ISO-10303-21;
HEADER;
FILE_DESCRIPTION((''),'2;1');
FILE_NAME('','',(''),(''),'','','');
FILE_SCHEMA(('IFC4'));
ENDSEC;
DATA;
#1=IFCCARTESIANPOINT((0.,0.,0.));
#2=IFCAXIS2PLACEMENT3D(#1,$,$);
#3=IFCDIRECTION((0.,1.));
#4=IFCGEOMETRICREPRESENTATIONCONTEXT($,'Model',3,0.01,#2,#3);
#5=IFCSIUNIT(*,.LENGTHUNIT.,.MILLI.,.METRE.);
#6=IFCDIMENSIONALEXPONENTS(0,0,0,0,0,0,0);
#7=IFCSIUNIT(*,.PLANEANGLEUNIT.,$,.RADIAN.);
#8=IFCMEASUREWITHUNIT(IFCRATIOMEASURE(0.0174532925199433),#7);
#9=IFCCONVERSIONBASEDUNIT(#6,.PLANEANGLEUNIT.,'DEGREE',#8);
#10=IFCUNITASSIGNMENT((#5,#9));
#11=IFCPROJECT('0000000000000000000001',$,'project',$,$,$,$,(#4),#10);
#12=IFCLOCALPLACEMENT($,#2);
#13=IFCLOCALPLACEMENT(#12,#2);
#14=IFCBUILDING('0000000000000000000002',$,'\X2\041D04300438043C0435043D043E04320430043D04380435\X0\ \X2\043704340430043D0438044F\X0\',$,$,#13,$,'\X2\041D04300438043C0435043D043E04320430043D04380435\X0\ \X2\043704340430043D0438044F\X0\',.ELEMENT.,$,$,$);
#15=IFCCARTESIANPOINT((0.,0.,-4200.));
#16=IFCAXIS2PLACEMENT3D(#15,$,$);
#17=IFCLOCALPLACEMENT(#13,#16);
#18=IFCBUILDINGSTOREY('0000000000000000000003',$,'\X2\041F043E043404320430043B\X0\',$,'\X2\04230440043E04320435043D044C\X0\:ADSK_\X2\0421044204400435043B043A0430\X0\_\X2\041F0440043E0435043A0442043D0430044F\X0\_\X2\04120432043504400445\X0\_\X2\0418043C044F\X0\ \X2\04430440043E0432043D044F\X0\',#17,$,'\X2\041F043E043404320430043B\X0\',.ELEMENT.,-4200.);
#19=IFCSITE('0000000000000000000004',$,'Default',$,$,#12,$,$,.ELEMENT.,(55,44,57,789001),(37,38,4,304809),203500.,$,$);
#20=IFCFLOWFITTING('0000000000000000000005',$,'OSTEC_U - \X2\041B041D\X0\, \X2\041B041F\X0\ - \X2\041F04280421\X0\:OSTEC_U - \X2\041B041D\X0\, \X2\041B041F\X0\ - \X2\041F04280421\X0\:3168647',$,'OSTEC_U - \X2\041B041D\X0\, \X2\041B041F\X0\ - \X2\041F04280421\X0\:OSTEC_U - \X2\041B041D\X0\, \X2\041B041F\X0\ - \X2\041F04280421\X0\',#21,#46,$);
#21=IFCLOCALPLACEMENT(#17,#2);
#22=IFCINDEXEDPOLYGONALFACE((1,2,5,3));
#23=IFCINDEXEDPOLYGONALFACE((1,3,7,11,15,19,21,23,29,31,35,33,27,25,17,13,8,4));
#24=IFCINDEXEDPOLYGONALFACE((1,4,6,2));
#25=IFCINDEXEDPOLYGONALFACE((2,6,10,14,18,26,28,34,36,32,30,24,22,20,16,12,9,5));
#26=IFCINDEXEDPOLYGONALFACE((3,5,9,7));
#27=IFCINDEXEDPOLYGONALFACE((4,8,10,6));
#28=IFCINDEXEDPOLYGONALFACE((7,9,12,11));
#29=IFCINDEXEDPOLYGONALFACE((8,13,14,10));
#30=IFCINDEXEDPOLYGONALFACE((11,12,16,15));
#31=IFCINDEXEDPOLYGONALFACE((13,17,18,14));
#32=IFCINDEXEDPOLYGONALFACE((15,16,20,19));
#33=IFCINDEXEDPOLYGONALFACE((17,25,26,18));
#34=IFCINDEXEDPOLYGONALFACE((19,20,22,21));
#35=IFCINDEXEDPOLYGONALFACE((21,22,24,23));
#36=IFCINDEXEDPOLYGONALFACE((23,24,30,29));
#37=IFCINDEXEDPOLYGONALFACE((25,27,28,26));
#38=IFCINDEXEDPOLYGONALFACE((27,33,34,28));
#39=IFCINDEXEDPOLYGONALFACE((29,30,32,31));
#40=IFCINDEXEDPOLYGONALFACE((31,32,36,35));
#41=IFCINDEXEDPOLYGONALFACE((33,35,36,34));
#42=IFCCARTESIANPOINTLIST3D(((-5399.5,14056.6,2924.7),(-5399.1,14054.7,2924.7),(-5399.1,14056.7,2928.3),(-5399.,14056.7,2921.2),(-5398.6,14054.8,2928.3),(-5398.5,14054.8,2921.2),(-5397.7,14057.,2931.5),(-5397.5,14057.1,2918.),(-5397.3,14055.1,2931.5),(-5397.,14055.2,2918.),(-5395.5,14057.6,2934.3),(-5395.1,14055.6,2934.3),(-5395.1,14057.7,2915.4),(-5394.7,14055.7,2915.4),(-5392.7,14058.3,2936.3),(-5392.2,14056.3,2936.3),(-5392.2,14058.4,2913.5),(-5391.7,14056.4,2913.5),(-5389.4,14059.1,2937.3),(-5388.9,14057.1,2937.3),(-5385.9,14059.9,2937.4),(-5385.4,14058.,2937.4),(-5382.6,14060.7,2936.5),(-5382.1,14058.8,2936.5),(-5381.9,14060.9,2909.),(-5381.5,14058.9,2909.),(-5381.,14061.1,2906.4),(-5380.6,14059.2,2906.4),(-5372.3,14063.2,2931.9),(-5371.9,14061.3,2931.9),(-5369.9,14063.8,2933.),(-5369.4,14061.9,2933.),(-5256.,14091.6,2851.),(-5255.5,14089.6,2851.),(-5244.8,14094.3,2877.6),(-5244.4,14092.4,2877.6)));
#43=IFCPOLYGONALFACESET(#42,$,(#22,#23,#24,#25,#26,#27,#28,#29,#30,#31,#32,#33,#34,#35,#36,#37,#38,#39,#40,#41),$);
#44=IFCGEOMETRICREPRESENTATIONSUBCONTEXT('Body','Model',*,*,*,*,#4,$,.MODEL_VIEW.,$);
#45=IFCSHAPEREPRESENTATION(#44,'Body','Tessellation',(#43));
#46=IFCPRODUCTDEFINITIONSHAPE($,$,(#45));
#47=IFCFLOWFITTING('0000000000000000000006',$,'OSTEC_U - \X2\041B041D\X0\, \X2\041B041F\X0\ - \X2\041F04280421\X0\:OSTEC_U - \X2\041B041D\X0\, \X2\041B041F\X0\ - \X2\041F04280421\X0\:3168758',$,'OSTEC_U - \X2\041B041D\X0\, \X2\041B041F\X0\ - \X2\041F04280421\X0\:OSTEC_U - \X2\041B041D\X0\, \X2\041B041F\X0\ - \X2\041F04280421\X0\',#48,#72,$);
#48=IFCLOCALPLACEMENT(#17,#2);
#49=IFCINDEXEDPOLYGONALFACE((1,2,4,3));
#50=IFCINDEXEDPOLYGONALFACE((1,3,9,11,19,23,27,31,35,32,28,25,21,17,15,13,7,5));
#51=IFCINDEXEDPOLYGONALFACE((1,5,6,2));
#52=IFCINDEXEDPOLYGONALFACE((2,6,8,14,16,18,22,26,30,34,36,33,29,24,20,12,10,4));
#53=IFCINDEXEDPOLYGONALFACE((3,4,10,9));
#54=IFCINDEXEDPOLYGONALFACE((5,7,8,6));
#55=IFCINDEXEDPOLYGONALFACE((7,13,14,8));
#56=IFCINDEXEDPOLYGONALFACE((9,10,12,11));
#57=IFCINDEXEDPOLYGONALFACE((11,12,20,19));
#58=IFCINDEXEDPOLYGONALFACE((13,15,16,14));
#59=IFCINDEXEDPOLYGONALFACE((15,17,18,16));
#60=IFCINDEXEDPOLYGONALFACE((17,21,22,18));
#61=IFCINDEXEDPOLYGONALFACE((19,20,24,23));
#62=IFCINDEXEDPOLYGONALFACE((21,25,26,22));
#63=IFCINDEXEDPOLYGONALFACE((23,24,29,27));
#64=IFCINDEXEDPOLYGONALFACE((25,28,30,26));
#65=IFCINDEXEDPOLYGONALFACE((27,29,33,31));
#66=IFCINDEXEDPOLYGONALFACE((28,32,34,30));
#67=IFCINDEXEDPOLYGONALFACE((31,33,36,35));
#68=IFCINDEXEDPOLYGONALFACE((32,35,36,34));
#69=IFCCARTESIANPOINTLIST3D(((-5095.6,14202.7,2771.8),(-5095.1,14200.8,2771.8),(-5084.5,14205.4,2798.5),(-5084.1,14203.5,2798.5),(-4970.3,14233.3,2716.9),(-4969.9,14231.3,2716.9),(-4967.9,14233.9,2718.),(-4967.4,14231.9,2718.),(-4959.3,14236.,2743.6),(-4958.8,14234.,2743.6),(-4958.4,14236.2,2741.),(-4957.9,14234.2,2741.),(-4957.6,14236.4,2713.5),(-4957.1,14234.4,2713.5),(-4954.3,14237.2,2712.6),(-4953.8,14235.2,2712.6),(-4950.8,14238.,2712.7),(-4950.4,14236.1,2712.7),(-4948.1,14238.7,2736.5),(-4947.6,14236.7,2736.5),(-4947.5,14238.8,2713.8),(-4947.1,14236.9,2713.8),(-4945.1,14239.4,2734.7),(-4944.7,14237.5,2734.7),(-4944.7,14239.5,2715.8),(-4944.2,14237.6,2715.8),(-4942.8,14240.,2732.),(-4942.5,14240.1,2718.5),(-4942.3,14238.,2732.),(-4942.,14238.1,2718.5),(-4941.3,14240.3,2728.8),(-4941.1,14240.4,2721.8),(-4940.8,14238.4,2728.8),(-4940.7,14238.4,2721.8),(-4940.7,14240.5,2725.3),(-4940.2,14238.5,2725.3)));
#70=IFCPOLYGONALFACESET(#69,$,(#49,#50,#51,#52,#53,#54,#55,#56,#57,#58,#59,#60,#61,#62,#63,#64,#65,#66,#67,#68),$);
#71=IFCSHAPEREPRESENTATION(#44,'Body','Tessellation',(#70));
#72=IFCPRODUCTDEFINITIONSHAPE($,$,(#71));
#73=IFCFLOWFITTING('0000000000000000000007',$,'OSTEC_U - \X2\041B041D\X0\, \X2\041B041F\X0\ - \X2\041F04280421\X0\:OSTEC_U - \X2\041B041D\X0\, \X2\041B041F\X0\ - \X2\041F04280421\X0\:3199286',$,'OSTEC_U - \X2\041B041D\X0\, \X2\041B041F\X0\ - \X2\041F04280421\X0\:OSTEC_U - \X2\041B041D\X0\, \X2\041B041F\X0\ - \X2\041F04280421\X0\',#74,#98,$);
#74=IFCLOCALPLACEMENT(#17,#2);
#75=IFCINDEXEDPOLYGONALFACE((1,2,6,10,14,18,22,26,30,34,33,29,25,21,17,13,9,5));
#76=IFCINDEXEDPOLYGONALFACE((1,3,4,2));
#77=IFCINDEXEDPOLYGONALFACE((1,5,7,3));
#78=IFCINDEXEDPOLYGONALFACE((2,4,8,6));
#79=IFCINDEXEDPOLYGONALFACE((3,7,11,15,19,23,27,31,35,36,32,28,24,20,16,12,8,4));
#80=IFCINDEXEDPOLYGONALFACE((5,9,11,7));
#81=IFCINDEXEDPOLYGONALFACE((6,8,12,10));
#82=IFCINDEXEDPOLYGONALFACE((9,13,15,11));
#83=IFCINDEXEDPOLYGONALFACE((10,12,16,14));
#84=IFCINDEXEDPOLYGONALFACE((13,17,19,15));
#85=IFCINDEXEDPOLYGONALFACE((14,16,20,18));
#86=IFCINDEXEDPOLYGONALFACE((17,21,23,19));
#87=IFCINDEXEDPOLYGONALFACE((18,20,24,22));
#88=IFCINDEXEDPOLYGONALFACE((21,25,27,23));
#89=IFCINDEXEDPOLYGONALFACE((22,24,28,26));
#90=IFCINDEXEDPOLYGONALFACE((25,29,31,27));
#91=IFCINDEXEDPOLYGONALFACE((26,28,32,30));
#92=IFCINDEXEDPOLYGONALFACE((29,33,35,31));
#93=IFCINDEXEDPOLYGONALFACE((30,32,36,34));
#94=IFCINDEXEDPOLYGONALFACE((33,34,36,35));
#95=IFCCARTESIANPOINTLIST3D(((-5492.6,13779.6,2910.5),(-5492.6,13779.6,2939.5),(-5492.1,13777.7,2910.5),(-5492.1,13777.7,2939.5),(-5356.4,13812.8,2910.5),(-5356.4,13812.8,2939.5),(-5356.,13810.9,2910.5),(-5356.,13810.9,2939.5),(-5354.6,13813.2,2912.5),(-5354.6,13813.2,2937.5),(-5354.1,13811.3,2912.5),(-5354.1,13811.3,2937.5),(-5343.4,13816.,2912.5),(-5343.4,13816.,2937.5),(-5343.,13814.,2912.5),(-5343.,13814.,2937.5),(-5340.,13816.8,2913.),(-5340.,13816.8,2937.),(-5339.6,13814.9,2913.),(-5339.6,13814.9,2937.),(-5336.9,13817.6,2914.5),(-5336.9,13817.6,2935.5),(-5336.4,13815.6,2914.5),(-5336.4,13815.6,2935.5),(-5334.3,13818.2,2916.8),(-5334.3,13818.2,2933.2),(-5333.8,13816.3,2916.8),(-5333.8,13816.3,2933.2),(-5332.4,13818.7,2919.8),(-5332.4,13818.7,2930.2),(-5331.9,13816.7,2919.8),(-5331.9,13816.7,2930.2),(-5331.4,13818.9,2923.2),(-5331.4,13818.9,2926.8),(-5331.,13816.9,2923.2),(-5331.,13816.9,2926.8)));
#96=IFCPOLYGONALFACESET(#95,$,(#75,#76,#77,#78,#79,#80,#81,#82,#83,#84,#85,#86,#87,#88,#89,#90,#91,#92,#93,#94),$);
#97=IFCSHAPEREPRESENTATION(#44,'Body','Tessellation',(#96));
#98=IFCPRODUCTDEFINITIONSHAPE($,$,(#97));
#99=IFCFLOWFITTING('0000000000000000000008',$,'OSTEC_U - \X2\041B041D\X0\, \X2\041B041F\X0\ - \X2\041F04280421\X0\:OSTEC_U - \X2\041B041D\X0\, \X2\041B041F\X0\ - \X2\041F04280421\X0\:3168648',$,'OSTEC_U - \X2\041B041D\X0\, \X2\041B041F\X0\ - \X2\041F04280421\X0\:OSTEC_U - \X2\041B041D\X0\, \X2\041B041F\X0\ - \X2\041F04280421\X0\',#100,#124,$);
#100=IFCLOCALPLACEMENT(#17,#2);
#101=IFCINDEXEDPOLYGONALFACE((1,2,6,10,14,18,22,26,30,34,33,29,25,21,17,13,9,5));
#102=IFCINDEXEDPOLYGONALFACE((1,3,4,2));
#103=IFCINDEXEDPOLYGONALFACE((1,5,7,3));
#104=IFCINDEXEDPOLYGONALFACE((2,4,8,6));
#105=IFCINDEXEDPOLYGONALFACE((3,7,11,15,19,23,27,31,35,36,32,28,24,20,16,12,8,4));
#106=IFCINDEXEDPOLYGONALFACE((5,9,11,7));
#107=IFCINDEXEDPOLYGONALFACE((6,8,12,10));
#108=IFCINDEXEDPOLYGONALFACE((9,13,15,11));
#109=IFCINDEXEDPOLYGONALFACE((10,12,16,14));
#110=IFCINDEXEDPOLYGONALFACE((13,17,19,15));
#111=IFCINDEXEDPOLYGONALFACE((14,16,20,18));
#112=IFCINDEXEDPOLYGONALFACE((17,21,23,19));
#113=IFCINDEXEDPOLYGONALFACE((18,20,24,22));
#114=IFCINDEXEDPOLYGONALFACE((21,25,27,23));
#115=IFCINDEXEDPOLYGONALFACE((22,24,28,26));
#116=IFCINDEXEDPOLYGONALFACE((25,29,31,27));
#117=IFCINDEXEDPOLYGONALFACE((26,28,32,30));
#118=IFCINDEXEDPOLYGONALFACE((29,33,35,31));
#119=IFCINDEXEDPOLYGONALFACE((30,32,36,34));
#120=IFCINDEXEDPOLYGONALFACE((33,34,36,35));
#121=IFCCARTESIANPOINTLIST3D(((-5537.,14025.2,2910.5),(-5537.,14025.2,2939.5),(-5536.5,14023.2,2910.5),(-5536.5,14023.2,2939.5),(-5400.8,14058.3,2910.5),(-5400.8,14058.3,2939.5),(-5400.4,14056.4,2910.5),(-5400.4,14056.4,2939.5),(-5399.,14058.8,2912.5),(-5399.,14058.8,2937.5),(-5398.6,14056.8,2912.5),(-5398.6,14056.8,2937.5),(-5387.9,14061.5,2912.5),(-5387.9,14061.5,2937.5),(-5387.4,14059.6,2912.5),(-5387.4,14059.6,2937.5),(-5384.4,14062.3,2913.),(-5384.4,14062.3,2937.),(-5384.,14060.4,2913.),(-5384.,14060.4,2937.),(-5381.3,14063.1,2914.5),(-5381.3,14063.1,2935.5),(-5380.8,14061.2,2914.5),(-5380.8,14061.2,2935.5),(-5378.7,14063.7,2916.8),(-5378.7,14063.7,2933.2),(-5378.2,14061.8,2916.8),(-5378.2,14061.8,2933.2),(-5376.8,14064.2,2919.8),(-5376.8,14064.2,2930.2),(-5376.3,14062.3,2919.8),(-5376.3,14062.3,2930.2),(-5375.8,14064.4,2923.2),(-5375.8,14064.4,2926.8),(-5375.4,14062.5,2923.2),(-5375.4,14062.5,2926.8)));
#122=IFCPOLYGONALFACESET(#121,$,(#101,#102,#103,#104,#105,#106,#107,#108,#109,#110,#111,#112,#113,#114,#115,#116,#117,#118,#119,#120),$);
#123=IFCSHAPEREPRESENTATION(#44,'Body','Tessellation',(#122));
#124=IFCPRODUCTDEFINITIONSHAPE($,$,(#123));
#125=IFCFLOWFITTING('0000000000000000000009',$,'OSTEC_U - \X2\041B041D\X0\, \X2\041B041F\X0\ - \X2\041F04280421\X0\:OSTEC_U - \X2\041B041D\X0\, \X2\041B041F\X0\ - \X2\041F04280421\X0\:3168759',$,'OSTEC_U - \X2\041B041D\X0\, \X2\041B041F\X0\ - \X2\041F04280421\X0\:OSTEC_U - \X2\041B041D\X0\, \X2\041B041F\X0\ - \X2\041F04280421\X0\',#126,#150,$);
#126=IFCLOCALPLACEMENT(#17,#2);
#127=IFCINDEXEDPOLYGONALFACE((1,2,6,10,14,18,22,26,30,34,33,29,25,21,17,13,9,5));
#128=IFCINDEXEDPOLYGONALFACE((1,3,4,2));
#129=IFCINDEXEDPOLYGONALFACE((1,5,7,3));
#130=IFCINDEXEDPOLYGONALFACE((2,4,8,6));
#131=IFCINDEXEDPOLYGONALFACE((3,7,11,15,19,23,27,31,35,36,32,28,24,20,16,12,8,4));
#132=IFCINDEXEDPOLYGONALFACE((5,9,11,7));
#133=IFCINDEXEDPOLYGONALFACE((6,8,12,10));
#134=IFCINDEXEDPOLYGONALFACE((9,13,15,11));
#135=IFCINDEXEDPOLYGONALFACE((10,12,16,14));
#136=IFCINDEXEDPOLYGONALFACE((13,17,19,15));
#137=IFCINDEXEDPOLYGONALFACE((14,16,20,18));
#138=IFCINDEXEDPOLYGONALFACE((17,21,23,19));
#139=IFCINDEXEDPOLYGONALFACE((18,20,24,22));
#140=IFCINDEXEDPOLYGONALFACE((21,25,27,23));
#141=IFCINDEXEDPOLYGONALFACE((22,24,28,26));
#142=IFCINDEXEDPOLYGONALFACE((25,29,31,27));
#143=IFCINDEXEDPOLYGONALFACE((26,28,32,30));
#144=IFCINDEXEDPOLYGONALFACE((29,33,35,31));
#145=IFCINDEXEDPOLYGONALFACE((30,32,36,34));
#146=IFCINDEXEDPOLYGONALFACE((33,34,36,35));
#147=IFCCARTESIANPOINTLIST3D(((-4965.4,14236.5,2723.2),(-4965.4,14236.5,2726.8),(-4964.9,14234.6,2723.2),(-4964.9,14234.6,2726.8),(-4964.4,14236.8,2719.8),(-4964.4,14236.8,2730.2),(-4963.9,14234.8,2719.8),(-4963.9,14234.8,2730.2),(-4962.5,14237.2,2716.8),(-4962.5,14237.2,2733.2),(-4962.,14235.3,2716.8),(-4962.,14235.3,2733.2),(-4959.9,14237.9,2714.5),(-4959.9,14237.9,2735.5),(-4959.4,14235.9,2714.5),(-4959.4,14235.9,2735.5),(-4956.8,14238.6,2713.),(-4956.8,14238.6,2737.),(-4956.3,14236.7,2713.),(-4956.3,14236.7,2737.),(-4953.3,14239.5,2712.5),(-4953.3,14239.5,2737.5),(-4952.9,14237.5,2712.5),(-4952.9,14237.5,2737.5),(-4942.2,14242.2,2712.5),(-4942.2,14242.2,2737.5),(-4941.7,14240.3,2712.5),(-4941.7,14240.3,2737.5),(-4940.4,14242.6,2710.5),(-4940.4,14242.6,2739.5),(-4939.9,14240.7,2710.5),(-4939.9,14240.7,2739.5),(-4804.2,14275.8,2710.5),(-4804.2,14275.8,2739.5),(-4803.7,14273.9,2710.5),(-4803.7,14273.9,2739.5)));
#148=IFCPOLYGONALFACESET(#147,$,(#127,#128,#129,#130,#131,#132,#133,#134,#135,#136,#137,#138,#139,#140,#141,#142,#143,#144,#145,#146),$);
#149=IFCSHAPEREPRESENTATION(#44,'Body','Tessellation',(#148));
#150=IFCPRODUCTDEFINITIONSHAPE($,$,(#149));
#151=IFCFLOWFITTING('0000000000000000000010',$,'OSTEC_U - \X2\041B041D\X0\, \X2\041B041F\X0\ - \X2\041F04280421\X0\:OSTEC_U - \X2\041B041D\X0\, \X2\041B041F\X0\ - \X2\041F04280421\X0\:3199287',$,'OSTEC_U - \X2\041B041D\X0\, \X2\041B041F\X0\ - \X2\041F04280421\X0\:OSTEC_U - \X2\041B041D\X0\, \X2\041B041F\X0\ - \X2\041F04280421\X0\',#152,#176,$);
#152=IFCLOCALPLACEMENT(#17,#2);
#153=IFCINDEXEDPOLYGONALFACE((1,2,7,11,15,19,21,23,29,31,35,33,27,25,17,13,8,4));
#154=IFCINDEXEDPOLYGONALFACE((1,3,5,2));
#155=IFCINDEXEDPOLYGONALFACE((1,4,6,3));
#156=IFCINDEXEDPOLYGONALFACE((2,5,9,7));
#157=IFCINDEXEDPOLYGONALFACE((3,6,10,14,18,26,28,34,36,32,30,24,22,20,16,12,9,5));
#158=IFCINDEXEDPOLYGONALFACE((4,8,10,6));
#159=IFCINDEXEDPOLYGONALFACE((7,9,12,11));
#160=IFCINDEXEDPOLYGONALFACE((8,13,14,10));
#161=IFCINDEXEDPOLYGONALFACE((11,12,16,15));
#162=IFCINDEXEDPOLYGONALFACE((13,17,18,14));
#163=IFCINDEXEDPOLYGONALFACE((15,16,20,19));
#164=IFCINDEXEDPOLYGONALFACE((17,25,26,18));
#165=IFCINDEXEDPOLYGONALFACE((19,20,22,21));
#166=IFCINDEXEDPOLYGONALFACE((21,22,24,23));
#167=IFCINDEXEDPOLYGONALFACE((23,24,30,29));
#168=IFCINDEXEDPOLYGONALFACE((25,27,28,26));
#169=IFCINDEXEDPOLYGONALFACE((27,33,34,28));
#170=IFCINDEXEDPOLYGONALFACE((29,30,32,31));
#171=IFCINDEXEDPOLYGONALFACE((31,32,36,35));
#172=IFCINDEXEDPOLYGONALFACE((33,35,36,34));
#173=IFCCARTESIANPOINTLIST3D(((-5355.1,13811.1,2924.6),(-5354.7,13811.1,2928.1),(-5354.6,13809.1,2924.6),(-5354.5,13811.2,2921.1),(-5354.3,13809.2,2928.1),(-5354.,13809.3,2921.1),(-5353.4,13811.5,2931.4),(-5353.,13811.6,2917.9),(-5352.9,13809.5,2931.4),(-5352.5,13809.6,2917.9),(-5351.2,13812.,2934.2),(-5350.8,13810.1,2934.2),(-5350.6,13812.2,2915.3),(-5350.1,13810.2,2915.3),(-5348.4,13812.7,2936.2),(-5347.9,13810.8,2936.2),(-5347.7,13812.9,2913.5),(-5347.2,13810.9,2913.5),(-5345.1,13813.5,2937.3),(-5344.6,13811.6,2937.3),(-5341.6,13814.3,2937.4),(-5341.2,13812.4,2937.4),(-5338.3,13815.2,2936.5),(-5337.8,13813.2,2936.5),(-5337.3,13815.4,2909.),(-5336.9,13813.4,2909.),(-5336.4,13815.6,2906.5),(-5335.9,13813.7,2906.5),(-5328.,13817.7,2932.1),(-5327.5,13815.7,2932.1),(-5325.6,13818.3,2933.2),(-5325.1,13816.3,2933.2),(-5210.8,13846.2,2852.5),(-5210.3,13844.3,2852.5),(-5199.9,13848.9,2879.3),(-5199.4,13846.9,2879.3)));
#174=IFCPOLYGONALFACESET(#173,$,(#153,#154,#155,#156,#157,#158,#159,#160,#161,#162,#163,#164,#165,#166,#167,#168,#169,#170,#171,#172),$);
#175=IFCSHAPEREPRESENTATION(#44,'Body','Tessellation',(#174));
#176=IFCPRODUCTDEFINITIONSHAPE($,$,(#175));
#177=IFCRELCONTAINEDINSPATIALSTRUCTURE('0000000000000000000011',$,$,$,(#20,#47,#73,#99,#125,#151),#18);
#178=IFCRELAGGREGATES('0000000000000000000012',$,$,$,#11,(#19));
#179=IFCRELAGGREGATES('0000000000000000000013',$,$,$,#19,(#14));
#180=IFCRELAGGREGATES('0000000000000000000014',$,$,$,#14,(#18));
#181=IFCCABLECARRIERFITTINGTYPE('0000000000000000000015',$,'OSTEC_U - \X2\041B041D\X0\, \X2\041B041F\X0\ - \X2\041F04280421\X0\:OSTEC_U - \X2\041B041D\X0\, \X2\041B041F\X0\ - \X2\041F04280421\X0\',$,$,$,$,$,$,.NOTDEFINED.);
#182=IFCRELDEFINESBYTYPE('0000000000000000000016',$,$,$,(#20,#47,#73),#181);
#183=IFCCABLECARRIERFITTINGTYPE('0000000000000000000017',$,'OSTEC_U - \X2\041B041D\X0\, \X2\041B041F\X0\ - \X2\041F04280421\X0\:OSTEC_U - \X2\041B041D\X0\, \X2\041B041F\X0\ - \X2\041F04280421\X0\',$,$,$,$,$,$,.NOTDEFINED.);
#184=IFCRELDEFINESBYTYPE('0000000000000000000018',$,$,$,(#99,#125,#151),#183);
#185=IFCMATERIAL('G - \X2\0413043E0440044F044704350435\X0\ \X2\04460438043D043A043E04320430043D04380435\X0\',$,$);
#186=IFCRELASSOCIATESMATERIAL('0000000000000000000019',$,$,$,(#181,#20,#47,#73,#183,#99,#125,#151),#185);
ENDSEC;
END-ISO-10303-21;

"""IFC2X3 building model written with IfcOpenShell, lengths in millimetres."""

from ifc_helpers import new_model, entity, si_unit, converted_unit, direction, frame, frame_2d, origin, place, context, subcontext, project, spatial, polyline, circle_curve, parameter, trimmed, segment, composite_curve, outline, extrude, source, transform, mapped, material, type_object, type_shapes, element, save


model = new_model("IFC2X3")

# Units and contexts
model_context = context("Model", 3, precision=0.01, world=origin(), true_north=direction((0.0, 1.0)))
body_context = subcontext(model_context, "Body", "Model", "MODEL_VIEW")
ifc_project = project(units=[si_unit("LENGTHUNIT", "METRE", prefix="MILLI"), converted_unit("PLANEANGLEUNIT", "DEGREE", entity("IfcRatioMeasure", 0.0174532925199433), si_unit("PLANEANGLEUNIT", "RADIAN"), dimensions=[0, 0, 0, 0, 0, 0, 0])], contexts=[model_context])

# Site, building, storey
site_placement = place(None, frame((0.0, 0.0, 0.0)))
site = spatial("IfcSite", under=ifc_project, at=site_placement, Name="Default", CompositionType="ELEMENT", RefLatitude=(55, 44, 57, 789001), RefLongitude=(37, 38, 4, 304809), RefElevation=203500.0)
building_placement = place(site_placement, origin())
building = spatial("IfcBuilding", under=site, at=building_placement, Name="Наименование здания", LongName="Наименование здания", CompositionType="ELEMENT")
storey_placement = place(building_placement, frame((0.0, 0.0, -4200.0)))
storey = spatial("IfcBuildingStorey", under=building, at=storey_placement, Name="Подвал", ObjectType="Уровень:ADSK_Стрелка_Проектная_Вверх_Имя уровня", LongName="Подвал", CompositionType="ELEMENT", Elevation=-4200.0)

# Flow fittings
ifc_material = material(Name="G - Горячее цинкование")
cable_carrier_fitting_type_1 = type_object("IfcCableCarrierFittingType", Name="OSTEC_U - ЛН, ЛП - ПШС:OSTEC_U - ЛН, ЛП - ПШС", PredefinedType="NOTDEFINED", material=ifc_material)
shared_shape_1 = source(origin(), body_context, "Body", "SweptSolid", [
    extrude(outline(composite_curve([segment(trimmed(circle_curve(frame_2d((-44.6, 0.0), x_axis=(1.0, 0.0)), 12.5), [parameter(90.0)], [parameter(270.0)], True, "PARAMETER"), True, "CONTINUOUS"), segment(polyline([(-44.6, -12.5), (-33.1, -12.5)]), True, "CONTINUOUS"), segment(polyline([(-33.1, -12.5), (-31.2, -14.5)]), True, "CONTINUOUS"), segment(polyline([(-31.2, -14.5), (108.9, -14.5)]), True, "CONTINUOUS"), segment(polyline([(108.9, -14.5), (108.9, 14.5)]), True, "CONTINUOUS"), segment(polyline([(108.9, 14.5), (-31.2, 14.5)]), True, "CONTINUOUS"), segment(polyline([(-31.2, 14.5), (-33.1, 12.5)]), True, "CONTINUOUS"), segment(polyline([(-33.1, 12.5), (-44.6, 12.5)]), True, "CONTINUOUS")], self_intersect=False)), frame((44.6, 0.0, 0.0)), (0.0, 0.0, 1.0), 2.0),
])
type_shapes(cable_carrier_fitting_type_1, [shared_shape_1])
for number, where, z_axis, x_axis, name in (
    (1, (-5387.4, 14059.6, 2925.0), (0.236821, -0.971553, 0.0), (0.892295, 0.217501, -0.395604), "OSTEC_U - ЛН, ЛП - ПШС:OSTEC_U - ЛН, ЛП - ПШС:3168647"),
    (2, (-4952.9, 14237.5, 2725.0), (0.236821, -0.971553, 0.0), (-0.893779, -0.217863, 0.39204), "OSTEC_U - ЛН, ЛП - ПШС:OSTEC_U - ЛН, ЛП - ПШС:3168758"),
    (3, (-5343.0, 13814.0, 2925.0), (-0.236821, 0.971553, 0.0), (-0.971553, -0.236821, 0.0), "OSTEC_U - ЛН, ЛП - ПШС:OSTEC_U - ЛН, ЛП - ПШС:3199286"),
):
    element("IfcFlowFitting", number, at=place(storey_placement, frame(where, z_axis=z_axis, x_axis=x_axis)), inside=storey, type_object=cable_carrier_fitting_type_1, material=ifc_material, Name=name, ObjectType="OSTEC_U - ЛН, ЛП - ПШС:OSTEC_U - ЛН, ЛП - ПШС", context=body_context, shape_type="MappedRepresentation", body=[
        mapped(shared_shape_1, transform((0.0, 0.0, 0.0), scale=1.0)),
    ])
cable_carrier_fitting_type_2 = type_object("IfcCableCarrierFittingType", Name="OSTEC_U - ЛН, ЛП - ПШС:OSTEC_U - ЛН, ЛП - ПШС", PredefinedType="NOTDEFINED", material=ifc_material)
shared_shape_2 = source(origin(), body_context, "Body", "SweptSolid", [
    extrude(outline(composite_curve([segment(trimmed(circle_curve(frame_2d((-44.6, 0.0), x_axis=(1.0, 0.0)), 12.5), [parameter(90.0)], [parameter(270.0)], True, "PARAMETER"), True, "CONTINUOUS"), segment(polyline([(-44.6, -12.5), (-33.1, -12.5)]), True, "CONTINUOUS"), segment(polyline([(-33.1, -12.5), (-31.2, -14.5)]), True, "CONTINUOUS"), segment(polyline([(-31.2, -14.5), (108.9, -14.5)]), True, "CONTINUOUS"), segment(polyline([(108.9, -14.5), (108.9, 14.5)]), True, "CONTINUOUS"), segment(polyline([(108.9, 14.5), (-31.2, 14.5)]), True, "CONTINUOUS"), segment(polyline([(-31.2, 14.5), (-33.1, 12.5)]), True, "CONTINUOUS"), segment(polyline([(-33.1, 12.5), (-44.6, 12.5)]), True, "CONTINUOUS")], self_intersect=False)), frame((44.6, 0.0, 0.0), z_axis=(0.0, 0.0, -1.0), x_axis=(1.0, 0.0, 0.0)), (0.0, 0.0, -1.0), 2.0),
])
type_shapes(cable_carrier_fitting_type_2, [shared_shape_2])
for number, where, z_axis, x_axis, name in (
    (4, (-5387.9, 14061.5, 2925.0), (0.236821, -0.971553, 0.0), (-0.971553, -0.236821, 0.0), "OSTEC_U - ЛН, ЛП - ПШС:OSTEC_U - ЛН, ЛП - ПШС:3168648"),
    (5, (-4953.3, 14239.5, 2725.0), (0.236821, -0.971553, 0.0), (0.971553, 0.236821, 0.0), "OSTEC_U - ЛН, ЛП - ПШС:OSTEC_U - ЛН, ЛП - ПШС:3168759"),
    (6, (-5342.5, 13812.1, 2925.0), (-0.236821, 0.971553, 0.0), (0.896628, 0.218557, -0.385085), "OSTEC_U - ЛН, ЛП - ПШС:OSTEC_U - ЛН, ЛП - ПШС:3199287"),
):
    element("IfcFlowFitting", number, at=place(storey_placement, frame(where, z_axis=z_axis, x_axis=x_axis)), inside=storey, type_object=cable_carrier_fitting_type_2, material=ifc_material, Name=name, ObjectType="OSTEC_U - ЛН, ЛП - ПШС:OSTEC_U - ЛН, ЛП - ПШС", context=body_context, shape_type="MappedRepresentation", body=[
        mapped(shared_shape_2, transform((0.0, 0.0, 0.0), scale=1.0)),
    ])

save(model, "model.ifc")
